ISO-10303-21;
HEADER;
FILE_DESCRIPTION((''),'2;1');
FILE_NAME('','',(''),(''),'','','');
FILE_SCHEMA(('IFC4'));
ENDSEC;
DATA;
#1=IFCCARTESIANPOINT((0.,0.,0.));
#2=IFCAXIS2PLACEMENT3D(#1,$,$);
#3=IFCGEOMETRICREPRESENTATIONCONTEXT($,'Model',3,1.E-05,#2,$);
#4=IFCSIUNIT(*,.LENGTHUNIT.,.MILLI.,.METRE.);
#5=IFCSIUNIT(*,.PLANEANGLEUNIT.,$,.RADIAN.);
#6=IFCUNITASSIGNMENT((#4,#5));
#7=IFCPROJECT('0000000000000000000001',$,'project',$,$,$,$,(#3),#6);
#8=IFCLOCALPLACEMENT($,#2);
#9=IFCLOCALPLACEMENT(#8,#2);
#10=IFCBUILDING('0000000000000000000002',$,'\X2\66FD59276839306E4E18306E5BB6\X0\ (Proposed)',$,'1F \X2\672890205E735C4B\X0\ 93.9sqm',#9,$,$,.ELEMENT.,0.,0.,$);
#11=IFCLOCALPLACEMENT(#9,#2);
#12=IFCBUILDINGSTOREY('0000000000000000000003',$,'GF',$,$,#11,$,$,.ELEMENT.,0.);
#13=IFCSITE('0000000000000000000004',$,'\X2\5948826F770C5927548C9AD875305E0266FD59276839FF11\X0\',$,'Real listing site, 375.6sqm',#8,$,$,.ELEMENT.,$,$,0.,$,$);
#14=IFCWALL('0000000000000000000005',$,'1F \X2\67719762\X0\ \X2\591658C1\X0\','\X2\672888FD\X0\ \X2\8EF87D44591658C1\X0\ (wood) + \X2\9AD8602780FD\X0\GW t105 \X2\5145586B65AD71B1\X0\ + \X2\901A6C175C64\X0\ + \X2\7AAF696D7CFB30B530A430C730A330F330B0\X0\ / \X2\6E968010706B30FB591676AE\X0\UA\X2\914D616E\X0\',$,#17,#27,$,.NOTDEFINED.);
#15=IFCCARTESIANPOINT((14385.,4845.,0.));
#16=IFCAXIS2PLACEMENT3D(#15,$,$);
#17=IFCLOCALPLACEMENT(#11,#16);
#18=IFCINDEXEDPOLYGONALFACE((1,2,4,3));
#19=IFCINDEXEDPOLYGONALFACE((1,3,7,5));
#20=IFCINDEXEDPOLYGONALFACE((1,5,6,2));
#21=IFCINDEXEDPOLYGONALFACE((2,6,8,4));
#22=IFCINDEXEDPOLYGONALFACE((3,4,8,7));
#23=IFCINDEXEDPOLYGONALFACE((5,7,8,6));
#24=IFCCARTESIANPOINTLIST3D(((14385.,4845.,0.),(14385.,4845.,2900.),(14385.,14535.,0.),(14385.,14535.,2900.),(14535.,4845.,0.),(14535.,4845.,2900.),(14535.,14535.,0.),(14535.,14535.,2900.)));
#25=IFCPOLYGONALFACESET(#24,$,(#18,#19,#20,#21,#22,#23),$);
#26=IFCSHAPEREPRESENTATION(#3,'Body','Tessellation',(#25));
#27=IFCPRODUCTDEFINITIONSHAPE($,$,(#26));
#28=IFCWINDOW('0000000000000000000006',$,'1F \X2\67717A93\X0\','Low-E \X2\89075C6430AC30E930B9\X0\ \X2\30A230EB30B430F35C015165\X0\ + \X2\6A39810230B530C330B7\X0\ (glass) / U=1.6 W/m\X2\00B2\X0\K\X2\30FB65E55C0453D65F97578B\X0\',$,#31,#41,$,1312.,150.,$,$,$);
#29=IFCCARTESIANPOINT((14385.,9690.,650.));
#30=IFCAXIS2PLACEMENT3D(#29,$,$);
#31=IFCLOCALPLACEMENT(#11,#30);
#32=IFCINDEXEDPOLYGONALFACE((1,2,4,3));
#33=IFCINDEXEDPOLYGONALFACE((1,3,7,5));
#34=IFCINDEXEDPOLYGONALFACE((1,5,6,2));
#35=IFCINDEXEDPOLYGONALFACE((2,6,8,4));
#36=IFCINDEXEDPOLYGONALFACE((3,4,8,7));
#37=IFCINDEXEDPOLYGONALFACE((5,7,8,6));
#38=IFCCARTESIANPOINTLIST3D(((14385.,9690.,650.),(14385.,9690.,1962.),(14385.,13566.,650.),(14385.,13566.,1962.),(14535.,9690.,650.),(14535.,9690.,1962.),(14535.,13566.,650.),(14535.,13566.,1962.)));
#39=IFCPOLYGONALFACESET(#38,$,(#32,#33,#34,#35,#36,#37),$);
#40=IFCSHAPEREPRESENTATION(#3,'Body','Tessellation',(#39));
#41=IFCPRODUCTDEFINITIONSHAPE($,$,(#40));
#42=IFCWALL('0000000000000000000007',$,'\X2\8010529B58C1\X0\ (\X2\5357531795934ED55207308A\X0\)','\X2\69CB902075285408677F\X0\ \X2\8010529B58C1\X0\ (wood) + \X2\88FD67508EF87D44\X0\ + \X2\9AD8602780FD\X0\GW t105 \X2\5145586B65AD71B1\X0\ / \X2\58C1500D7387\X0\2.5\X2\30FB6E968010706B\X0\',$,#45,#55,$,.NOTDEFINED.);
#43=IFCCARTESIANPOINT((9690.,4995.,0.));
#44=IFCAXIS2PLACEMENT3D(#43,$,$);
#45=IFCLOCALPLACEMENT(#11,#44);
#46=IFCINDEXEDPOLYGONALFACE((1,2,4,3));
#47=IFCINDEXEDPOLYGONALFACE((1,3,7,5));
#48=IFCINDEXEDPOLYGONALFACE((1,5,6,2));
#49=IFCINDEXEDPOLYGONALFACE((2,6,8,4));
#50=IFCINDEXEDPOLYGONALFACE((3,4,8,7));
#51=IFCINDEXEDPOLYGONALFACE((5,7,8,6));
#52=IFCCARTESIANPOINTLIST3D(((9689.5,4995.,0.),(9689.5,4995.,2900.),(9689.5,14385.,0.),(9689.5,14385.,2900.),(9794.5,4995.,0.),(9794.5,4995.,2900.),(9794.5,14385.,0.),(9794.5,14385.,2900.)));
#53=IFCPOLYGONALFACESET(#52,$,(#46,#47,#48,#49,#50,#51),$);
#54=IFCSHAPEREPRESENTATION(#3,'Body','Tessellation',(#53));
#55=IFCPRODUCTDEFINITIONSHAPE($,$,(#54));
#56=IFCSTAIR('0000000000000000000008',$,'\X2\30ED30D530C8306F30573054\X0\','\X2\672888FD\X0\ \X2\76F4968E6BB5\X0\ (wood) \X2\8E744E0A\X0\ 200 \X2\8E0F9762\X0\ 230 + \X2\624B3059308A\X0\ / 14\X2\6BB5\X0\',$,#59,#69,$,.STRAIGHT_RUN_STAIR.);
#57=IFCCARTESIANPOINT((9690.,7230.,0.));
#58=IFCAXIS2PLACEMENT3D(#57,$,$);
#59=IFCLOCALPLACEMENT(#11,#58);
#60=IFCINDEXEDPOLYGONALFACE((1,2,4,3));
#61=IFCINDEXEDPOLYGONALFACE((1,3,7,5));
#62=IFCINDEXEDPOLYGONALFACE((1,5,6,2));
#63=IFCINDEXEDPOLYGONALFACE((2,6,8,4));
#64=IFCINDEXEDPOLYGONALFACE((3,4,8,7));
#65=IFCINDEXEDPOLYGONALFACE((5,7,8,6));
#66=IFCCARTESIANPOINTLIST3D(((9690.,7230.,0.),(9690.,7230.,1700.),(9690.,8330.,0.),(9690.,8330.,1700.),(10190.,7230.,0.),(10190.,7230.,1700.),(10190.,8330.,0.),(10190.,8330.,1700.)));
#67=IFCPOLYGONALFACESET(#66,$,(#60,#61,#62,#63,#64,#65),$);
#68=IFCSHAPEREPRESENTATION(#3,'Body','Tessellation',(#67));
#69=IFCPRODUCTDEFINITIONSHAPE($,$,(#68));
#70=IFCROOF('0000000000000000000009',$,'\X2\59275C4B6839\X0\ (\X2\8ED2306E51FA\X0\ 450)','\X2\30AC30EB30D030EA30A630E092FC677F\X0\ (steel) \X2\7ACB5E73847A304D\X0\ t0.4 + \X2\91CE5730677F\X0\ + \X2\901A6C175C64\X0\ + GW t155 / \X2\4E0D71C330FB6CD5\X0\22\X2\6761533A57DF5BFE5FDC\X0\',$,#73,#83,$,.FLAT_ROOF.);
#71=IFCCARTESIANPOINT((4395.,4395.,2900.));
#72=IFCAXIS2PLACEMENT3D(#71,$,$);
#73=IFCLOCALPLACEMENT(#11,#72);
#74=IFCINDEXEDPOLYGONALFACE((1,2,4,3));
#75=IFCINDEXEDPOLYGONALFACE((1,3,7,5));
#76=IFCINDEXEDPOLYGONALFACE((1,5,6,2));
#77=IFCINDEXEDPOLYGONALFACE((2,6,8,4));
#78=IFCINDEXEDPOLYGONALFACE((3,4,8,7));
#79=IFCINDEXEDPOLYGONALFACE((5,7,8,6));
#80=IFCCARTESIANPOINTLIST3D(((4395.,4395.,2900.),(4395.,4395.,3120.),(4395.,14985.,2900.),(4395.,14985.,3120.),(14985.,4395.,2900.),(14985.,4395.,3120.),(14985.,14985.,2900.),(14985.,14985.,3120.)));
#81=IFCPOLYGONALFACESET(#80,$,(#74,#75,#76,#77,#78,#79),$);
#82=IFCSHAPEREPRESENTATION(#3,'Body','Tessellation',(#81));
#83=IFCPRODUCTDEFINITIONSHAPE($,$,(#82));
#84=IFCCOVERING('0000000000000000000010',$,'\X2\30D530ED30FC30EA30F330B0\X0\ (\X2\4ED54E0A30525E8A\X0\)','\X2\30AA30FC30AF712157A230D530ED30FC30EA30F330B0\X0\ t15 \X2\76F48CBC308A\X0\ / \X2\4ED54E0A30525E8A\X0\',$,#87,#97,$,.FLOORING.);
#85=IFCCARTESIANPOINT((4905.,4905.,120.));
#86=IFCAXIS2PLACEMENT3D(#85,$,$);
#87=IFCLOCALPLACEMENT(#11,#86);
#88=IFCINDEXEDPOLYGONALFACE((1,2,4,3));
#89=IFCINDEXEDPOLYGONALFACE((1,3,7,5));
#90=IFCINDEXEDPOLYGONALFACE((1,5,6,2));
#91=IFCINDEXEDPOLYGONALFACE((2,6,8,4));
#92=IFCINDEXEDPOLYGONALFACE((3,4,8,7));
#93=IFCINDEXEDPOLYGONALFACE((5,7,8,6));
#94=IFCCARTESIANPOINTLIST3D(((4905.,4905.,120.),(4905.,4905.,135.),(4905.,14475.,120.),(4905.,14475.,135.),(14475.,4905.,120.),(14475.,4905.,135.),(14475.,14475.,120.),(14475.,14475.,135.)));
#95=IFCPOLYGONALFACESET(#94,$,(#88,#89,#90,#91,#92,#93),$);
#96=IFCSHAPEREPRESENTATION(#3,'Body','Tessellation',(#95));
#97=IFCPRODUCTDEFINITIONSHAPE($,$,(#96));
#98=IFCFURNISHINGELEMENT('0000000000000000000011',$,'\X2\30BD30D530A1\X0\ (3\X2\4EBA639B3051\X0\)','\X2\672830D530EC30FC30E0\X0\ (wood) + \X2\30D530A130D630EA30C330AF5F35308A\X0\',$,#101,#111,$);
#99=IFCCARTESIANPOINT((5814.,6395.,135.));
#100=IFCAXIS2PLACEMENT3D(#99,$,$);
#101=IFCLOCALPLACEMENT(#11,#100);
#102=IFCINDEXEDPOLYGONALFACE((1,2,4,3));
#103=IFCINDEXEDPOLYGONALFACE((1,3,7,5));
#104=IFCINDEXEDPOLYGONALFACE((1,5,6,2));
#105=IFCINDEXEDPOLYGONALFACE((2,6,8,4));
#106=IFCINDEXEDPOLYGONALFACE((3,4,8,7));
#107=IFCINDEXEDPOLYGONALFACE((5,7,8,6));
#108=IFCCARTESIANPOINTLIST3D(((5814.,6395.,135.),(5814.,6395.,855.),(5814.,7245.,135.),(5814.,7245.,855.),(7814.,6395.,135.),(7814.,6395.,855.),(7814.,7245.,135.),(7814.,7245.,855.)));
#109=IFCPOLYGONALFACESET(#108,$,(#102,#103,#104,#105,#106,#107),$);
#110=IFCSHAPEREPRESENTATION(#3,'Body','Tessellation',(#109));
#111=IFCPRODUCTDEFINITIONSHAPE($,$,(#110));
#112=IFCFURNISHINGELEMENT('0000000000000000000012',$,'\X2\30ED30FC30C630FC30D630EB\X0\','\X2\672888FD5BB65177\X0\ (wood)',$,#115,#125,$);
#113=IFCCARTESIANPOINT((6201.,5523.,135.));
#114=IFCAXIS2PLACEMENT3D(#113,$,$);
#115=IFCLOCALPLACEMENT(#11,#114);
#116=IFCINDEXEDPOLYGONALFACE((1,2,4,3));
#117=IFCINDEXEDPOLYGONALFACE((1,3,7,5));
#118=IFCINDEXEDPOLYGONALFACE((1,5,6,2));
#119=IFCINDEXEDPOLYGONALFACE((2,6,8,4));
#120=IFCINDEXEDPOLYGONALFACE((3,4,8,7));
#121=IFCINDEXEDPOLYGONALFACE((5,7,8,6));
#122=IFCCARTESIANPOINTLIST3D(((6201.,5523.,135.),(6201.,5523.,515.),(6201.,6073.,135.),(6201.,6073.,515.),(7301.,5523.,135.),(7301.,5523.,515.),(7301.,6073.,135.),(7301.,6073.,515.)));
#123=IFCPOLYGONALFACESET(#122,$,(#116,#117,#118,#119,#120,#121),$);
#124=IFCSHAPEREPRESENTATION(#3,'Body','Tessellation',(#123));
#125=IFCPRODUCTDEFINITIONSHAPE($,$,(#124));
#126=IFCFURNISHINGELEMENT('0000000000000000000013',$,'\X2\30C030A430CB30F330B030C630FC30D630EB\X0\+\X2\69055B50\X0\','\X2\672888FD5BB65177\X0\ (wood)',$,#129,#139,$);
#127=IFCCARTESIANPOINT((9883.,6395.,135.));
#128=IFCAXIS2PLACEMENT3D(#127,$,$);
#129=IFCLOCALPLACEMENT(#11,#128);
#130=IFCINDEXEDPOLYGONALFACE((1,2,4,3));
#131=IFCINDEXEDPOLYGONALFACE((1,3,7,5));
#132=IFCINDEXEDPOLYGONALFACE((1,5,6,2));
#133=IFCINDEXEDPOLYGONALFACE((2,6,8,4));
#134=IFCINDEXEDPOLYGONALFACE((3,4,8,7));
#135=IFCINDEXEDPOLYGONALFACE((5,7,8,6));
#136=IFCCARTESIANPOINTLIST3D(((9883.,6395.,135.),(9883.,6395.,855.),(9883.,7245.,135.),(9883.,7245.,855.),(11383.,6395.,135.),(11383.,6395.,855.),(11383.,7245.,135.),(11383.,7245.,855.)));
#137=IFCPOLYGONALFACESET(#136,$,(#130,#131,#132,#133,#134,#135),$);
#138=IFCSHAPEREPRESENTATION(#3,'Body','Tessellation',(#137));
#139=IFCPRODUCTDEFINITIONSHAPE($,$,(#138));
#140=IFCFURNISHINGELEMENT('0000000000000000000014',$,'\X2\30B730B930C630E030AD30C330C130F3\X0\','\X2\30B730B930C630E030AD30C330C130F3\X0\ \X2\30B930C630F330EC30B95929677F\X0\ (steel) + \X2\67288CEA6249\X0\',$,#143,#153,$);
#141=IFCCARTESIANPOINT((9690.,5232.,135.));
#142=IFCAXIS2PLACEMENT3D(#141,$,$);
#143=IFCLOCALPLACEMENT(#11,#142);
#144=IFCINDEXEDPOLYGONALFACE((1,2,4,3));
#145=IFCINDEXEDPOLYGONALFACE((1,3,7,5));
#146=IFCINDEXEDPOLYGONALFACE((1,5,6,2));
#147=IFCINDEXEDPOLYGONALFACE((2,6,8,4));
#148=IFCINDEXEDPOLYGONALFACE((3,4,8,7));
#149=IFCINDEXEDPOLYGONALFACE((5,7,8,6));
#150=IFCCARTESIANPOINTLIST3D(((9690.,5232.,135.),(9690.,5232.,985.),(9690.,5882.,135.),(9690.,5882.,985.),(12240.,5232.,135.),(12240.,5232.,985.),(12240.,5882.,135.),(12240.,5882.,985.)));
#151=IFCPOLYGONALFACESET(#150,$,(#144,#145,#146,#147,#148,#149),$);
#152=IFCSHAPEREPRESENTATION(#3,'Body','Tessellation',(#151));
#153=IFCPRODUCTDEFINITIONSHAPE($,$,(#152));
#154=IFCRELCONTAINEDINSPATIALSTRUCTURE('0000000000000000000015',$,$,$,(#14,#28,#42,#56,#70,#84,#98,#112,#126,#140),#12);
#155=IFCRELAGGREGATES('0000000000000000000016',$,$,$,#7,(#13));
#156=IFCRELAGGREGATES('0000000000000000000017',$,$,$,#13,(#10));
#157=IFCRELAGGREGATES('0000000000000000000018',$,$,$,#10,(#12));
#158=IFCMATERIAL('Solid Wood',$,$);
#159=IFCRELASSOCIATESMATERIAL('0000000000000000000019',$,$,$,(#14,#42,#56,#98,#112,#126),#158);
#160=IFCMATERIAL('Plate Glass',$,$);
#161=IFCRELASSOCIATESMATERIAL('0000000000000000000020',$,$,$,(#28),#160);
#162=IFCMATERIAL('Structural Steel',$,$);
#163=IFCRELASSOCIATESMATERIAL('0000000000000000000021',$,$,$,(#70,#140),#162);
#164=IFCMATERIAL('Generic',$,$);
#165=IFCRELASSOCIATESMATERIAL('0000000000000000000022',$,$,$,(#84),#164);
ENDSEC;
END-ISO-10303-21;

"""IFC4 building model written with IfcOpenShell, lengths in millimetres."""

from ifc_helpers import new_model, si_unit, frame, frame_2d, origin, place, context, project, spatial, rectangle, extrude, material, element, fill, save


model = new_model("IFC4")

# Units and contexts
model_context = context("Model", 3, precision=1e-05, world=origin())
ifc_project = project(units=[si_unit("LENGTHUNIT", "METRE", prefix="MILLI"), si_unit("PLANEANGLEUNIT", "RADIAN")], contexts=[model_context])

# Site, building, storey
site_placement = place(None, origin())
site = spatial("IfcSite", under=ifc_project, at=site_placement, Name="奈良県大和高田市曽大根１", ObjectType="Real listing site, 375.6sqm", CompositionType="ELEMENT", RefElevation=0.0)
building_placement = place(site_placement, origin())
building = spatial("IfcBuilding", under=site, at=building_placement, Name="曽大根の丘の家 (Proposed)", ObjectType="1F 木造平屋 93.9sqm", CompositionType="ELEMENT", ElevationOfRefHeight=0.0, ElevationOfTerrain=0.0)
storey_placement = place(building_placement, origin())
storey = spatial("IfcBuildingStorey", under=building, at=storey_placement, Name="GF", CompositionType="ELEMENT", Elevation=0.0)

# Shared definitions
ifc_material_1 = material(Name="Solid Wood")

# Shared definitions
ifc_material_2 = material(Name="Plate Glass")

# Wall, opening, window
wall_1_placement = place(storey_placement, frame((14385.0, 4845.0, 0.0)))
wall_1 = element("IfcWall", 1, at=wall_1_placement, inside=storey, material=ifc_material_1, Name="1F 東面 外壁", Description="木製 軸組外壁 (wood) + 高性能GW t105 充填断熱 + 通気層 + 窯業系サイディング / 準耐火・外皮UA配慮", PredefinedType="NOTDEFINED", context=model_context, shape_type="SweptSolid", body=[
    extrude(rectangle(XDim=150.0, YDim=9690.0, at=frame_2d((75.0, 4845.0))), frame((14385.0, 4845.0, 0.0)), (0.0, 0.0, 1.0), 2900.0),
])
opening_1_placement = place(storey_placement, frame((14385.0, 9690.0, 650.0)))
opening_1 = element("IfcOpeningElement", 2, at=opening_1_placement, cuts=wall_1, PredefinedType="NOTDEFINED", context=model_context, shape_type="SweptSolid", body=[
    extrude(rectangle(XDim=150.0, YDim=3876.0, at=frame_2d((75.0, 1938.0))), frame((14385.0, 9690.0, 650.0)), (0.0, 0.0, 1.0), 1312.0),
])
window_1_placement = place(storey_placement, frame((14385.0, 9690.0, 650.0)))
window_1 = element("IfcWindow", 3, at=window_1_placement, inside=storey, material=ifc_material_2, Name="1F 東窓", Description="Low-E 複層ガラス アルゴン封入 + 樹脂サッシ (glass) / U=1.6 W/m²K・日射取得型", OverallHeight=1312.0, OverallWidth=150.0, context=model_context, shape_type="SweptSolid", body=[
    extrude(rectangle(XDim=150.0, YDim=3876.0, at=frame_2d((75.0, 1938.0))), frame((14385.0, 9690.0, 650.0)), (0.0, 0.0, 1.0), 1312.0),
])
fill(opening_1, window_1)

# Wall
wall_2_placement = place(storey_placement, frame((9690.0, 4995.0, 0.0)))
element("IfcWall", 4, at=wall_2_placement, inside=storey, material=ifc_material_1, Name="耐力壁 (南北間仕切り)", Description="構造用合板 耐力壁 (wood) + 製材軸組 + 高性能GW t105 充填断熱 / 壁倍率2.5・準耐火", PredefinedType="NOTDEFINED", context=model_context, shape_type="SweptSolid", body=[
    extrude(rectangle(XDim=105.0, YDim=9390.0, at=frame_2d((52.0, 4695.0))), frame((9690.0, 4995.0, 0.0)), (0.0, 0.0, 1.0), 2900.0),
])

# Stair
stair_placement = place(storey_placement, frame((9690.0, 7230.0, 0.0)))
element("IfcStair", 5, at=stair_placement, inside=storey, material=ifc_material_1, Name="ロフトはしご", Description="木製 直階段 (wood) 蹴上 200 踏面 230 + 手すり / 14段", PredefinedType="STRAIGHT_RUN_STAIR", context=model_context, shape_type="SweptSolid", body=[
    extrude(rectangle(XDim=500.0, YDim=1100.0, at=frame_2d((250.0, 550.0))), frame((9690.0, 7230.0, 0.0)), (0.0, 0.0, 1.0), 1700.0),
])

# Roof
ifc_material_3 = material(Name="Structural Steel")
roof_placement = place(storey_placement, frame((4395.0, 4395.0, 2900.0)))
element("IfcRoof", 6, at=roof_placement, inside=storey, material=ifc_material_3, Name="大屋根 (軒の出 450)", Description="ガルバリウム鋼板 (steel) 立平葺き t0.4 + 野地板 + 通気層 + GW t155 / 不燃・法22条区域対応", PredefinedType="FLAT_ROOF", context=model_context, shape_type="SweptSolid", body=[
    extrude(rectangle(XDim=10590.0, YDim=10590.0, at=frame_2d((5295.0, 5295.0))), frame((4395.0, 4395.0, 2900.0)), (0.0, 0.0, 1.0), 220.0),
])

# Covering
ifc_material_4 = material(Name="Generic")
covering_placement = place(storey_placement, frame((4905.0, 4905.0, 120.0)))
element("IfcCovering", 7, at=covering_placement, inside=storey, material=ifc_material_4, Name="フローリング (仕上げ床)", Description="オーク無垢フローリング t15 直貼り / 仕上げ床", PredefinedType="FLOORING", context=model_context, shape_type="SweptSolid", body=[
    extrude(rectangle(XDim=9570.0, YDim=9570.0, at=frame_2d((4785.0, 4785.0))), frame((4905.0, 4905.0, 120.0)), (0.0, 0.0, 1.0), 15.0),
])

# Furnishing elements
furnishing_1_placement = place(storey_placement, frame((5814.0, 6395.0, 135.0)))
element("IfcFurnishingElement", 8, at=furnishing_1_placement, inside=storey, material=ifc_material_1, Name="ソファ (3人掛け)", Description="木フレーム (wood) + ファブリック張り", context=model_context, shape_type="SweptSolid", body=[
    extrude(rectangle(XDim=2000.0, YDim=850.0, at=frame_2d((1000.0, 425.0))), frame((5814.0, 6395.0, 135.0)), (0.0, 0.0, 1.0), 720.0),
])
furnishing_2_placement = place(storey_placement, frame((6201.0, 5523.0, 135.0)))
element("IfcFurnishingElement", 9, at=furnishing_2_placement, inside=storey, material=ifc_material_1, Name="ローテーブル", Description="木製家具 (wood)", context=model_context, shape_type="SweptSolid", body=[
    extrude(rectangle(XDim=1100.0, YDim=550.0, at=frame_2d((550.0, 275.0))), frame((6201.0, 5523.0, 135.0)), (0.0, 0.0, 1.0), 380.0),
])
furnishing_3_placement = place(storey_placement, frame((9883.0, 6395.0, 135.0)))
element("IfcFurnishingElement", 10, at=furnishing_3_placement, inside=storey, material=ifc_material_1, Name="ダイニングテーブル+椅子", Description="木製家具 (wood)", context=model_context, shape_type="SweptSolid", body=[
    extrude(rectangle(XDim=1500.0, YDim=850.0, at=frame_2d((750.0, 425.0))), frame((9883.0, 6395.0, 135.0)), (0.0, 0.0, 1.0), 720.0),
])
furnishing_4_placement = place(storey_placement, frame((9690.0, 5232.0, 135.0)))
element("IfcFurnishingElement", 11, at=furnishing_4_placement, inside=storey, material=ifc_material_3, Name="システムキッチン", Description="システムキッチン ステンレス天板 (steel) + 木質扉", context=model_context, shape_type="SweptSolid", body=[
    extrude(rectangle(XDim=2550.0, YDim=650.0, at=frame_2d((1275.0, 325.0))), frame((9690.0, 5232.0, 135.0)), (0.0, 0.0, 1.0), 850.0),
])

save(model, "model.ifc")
